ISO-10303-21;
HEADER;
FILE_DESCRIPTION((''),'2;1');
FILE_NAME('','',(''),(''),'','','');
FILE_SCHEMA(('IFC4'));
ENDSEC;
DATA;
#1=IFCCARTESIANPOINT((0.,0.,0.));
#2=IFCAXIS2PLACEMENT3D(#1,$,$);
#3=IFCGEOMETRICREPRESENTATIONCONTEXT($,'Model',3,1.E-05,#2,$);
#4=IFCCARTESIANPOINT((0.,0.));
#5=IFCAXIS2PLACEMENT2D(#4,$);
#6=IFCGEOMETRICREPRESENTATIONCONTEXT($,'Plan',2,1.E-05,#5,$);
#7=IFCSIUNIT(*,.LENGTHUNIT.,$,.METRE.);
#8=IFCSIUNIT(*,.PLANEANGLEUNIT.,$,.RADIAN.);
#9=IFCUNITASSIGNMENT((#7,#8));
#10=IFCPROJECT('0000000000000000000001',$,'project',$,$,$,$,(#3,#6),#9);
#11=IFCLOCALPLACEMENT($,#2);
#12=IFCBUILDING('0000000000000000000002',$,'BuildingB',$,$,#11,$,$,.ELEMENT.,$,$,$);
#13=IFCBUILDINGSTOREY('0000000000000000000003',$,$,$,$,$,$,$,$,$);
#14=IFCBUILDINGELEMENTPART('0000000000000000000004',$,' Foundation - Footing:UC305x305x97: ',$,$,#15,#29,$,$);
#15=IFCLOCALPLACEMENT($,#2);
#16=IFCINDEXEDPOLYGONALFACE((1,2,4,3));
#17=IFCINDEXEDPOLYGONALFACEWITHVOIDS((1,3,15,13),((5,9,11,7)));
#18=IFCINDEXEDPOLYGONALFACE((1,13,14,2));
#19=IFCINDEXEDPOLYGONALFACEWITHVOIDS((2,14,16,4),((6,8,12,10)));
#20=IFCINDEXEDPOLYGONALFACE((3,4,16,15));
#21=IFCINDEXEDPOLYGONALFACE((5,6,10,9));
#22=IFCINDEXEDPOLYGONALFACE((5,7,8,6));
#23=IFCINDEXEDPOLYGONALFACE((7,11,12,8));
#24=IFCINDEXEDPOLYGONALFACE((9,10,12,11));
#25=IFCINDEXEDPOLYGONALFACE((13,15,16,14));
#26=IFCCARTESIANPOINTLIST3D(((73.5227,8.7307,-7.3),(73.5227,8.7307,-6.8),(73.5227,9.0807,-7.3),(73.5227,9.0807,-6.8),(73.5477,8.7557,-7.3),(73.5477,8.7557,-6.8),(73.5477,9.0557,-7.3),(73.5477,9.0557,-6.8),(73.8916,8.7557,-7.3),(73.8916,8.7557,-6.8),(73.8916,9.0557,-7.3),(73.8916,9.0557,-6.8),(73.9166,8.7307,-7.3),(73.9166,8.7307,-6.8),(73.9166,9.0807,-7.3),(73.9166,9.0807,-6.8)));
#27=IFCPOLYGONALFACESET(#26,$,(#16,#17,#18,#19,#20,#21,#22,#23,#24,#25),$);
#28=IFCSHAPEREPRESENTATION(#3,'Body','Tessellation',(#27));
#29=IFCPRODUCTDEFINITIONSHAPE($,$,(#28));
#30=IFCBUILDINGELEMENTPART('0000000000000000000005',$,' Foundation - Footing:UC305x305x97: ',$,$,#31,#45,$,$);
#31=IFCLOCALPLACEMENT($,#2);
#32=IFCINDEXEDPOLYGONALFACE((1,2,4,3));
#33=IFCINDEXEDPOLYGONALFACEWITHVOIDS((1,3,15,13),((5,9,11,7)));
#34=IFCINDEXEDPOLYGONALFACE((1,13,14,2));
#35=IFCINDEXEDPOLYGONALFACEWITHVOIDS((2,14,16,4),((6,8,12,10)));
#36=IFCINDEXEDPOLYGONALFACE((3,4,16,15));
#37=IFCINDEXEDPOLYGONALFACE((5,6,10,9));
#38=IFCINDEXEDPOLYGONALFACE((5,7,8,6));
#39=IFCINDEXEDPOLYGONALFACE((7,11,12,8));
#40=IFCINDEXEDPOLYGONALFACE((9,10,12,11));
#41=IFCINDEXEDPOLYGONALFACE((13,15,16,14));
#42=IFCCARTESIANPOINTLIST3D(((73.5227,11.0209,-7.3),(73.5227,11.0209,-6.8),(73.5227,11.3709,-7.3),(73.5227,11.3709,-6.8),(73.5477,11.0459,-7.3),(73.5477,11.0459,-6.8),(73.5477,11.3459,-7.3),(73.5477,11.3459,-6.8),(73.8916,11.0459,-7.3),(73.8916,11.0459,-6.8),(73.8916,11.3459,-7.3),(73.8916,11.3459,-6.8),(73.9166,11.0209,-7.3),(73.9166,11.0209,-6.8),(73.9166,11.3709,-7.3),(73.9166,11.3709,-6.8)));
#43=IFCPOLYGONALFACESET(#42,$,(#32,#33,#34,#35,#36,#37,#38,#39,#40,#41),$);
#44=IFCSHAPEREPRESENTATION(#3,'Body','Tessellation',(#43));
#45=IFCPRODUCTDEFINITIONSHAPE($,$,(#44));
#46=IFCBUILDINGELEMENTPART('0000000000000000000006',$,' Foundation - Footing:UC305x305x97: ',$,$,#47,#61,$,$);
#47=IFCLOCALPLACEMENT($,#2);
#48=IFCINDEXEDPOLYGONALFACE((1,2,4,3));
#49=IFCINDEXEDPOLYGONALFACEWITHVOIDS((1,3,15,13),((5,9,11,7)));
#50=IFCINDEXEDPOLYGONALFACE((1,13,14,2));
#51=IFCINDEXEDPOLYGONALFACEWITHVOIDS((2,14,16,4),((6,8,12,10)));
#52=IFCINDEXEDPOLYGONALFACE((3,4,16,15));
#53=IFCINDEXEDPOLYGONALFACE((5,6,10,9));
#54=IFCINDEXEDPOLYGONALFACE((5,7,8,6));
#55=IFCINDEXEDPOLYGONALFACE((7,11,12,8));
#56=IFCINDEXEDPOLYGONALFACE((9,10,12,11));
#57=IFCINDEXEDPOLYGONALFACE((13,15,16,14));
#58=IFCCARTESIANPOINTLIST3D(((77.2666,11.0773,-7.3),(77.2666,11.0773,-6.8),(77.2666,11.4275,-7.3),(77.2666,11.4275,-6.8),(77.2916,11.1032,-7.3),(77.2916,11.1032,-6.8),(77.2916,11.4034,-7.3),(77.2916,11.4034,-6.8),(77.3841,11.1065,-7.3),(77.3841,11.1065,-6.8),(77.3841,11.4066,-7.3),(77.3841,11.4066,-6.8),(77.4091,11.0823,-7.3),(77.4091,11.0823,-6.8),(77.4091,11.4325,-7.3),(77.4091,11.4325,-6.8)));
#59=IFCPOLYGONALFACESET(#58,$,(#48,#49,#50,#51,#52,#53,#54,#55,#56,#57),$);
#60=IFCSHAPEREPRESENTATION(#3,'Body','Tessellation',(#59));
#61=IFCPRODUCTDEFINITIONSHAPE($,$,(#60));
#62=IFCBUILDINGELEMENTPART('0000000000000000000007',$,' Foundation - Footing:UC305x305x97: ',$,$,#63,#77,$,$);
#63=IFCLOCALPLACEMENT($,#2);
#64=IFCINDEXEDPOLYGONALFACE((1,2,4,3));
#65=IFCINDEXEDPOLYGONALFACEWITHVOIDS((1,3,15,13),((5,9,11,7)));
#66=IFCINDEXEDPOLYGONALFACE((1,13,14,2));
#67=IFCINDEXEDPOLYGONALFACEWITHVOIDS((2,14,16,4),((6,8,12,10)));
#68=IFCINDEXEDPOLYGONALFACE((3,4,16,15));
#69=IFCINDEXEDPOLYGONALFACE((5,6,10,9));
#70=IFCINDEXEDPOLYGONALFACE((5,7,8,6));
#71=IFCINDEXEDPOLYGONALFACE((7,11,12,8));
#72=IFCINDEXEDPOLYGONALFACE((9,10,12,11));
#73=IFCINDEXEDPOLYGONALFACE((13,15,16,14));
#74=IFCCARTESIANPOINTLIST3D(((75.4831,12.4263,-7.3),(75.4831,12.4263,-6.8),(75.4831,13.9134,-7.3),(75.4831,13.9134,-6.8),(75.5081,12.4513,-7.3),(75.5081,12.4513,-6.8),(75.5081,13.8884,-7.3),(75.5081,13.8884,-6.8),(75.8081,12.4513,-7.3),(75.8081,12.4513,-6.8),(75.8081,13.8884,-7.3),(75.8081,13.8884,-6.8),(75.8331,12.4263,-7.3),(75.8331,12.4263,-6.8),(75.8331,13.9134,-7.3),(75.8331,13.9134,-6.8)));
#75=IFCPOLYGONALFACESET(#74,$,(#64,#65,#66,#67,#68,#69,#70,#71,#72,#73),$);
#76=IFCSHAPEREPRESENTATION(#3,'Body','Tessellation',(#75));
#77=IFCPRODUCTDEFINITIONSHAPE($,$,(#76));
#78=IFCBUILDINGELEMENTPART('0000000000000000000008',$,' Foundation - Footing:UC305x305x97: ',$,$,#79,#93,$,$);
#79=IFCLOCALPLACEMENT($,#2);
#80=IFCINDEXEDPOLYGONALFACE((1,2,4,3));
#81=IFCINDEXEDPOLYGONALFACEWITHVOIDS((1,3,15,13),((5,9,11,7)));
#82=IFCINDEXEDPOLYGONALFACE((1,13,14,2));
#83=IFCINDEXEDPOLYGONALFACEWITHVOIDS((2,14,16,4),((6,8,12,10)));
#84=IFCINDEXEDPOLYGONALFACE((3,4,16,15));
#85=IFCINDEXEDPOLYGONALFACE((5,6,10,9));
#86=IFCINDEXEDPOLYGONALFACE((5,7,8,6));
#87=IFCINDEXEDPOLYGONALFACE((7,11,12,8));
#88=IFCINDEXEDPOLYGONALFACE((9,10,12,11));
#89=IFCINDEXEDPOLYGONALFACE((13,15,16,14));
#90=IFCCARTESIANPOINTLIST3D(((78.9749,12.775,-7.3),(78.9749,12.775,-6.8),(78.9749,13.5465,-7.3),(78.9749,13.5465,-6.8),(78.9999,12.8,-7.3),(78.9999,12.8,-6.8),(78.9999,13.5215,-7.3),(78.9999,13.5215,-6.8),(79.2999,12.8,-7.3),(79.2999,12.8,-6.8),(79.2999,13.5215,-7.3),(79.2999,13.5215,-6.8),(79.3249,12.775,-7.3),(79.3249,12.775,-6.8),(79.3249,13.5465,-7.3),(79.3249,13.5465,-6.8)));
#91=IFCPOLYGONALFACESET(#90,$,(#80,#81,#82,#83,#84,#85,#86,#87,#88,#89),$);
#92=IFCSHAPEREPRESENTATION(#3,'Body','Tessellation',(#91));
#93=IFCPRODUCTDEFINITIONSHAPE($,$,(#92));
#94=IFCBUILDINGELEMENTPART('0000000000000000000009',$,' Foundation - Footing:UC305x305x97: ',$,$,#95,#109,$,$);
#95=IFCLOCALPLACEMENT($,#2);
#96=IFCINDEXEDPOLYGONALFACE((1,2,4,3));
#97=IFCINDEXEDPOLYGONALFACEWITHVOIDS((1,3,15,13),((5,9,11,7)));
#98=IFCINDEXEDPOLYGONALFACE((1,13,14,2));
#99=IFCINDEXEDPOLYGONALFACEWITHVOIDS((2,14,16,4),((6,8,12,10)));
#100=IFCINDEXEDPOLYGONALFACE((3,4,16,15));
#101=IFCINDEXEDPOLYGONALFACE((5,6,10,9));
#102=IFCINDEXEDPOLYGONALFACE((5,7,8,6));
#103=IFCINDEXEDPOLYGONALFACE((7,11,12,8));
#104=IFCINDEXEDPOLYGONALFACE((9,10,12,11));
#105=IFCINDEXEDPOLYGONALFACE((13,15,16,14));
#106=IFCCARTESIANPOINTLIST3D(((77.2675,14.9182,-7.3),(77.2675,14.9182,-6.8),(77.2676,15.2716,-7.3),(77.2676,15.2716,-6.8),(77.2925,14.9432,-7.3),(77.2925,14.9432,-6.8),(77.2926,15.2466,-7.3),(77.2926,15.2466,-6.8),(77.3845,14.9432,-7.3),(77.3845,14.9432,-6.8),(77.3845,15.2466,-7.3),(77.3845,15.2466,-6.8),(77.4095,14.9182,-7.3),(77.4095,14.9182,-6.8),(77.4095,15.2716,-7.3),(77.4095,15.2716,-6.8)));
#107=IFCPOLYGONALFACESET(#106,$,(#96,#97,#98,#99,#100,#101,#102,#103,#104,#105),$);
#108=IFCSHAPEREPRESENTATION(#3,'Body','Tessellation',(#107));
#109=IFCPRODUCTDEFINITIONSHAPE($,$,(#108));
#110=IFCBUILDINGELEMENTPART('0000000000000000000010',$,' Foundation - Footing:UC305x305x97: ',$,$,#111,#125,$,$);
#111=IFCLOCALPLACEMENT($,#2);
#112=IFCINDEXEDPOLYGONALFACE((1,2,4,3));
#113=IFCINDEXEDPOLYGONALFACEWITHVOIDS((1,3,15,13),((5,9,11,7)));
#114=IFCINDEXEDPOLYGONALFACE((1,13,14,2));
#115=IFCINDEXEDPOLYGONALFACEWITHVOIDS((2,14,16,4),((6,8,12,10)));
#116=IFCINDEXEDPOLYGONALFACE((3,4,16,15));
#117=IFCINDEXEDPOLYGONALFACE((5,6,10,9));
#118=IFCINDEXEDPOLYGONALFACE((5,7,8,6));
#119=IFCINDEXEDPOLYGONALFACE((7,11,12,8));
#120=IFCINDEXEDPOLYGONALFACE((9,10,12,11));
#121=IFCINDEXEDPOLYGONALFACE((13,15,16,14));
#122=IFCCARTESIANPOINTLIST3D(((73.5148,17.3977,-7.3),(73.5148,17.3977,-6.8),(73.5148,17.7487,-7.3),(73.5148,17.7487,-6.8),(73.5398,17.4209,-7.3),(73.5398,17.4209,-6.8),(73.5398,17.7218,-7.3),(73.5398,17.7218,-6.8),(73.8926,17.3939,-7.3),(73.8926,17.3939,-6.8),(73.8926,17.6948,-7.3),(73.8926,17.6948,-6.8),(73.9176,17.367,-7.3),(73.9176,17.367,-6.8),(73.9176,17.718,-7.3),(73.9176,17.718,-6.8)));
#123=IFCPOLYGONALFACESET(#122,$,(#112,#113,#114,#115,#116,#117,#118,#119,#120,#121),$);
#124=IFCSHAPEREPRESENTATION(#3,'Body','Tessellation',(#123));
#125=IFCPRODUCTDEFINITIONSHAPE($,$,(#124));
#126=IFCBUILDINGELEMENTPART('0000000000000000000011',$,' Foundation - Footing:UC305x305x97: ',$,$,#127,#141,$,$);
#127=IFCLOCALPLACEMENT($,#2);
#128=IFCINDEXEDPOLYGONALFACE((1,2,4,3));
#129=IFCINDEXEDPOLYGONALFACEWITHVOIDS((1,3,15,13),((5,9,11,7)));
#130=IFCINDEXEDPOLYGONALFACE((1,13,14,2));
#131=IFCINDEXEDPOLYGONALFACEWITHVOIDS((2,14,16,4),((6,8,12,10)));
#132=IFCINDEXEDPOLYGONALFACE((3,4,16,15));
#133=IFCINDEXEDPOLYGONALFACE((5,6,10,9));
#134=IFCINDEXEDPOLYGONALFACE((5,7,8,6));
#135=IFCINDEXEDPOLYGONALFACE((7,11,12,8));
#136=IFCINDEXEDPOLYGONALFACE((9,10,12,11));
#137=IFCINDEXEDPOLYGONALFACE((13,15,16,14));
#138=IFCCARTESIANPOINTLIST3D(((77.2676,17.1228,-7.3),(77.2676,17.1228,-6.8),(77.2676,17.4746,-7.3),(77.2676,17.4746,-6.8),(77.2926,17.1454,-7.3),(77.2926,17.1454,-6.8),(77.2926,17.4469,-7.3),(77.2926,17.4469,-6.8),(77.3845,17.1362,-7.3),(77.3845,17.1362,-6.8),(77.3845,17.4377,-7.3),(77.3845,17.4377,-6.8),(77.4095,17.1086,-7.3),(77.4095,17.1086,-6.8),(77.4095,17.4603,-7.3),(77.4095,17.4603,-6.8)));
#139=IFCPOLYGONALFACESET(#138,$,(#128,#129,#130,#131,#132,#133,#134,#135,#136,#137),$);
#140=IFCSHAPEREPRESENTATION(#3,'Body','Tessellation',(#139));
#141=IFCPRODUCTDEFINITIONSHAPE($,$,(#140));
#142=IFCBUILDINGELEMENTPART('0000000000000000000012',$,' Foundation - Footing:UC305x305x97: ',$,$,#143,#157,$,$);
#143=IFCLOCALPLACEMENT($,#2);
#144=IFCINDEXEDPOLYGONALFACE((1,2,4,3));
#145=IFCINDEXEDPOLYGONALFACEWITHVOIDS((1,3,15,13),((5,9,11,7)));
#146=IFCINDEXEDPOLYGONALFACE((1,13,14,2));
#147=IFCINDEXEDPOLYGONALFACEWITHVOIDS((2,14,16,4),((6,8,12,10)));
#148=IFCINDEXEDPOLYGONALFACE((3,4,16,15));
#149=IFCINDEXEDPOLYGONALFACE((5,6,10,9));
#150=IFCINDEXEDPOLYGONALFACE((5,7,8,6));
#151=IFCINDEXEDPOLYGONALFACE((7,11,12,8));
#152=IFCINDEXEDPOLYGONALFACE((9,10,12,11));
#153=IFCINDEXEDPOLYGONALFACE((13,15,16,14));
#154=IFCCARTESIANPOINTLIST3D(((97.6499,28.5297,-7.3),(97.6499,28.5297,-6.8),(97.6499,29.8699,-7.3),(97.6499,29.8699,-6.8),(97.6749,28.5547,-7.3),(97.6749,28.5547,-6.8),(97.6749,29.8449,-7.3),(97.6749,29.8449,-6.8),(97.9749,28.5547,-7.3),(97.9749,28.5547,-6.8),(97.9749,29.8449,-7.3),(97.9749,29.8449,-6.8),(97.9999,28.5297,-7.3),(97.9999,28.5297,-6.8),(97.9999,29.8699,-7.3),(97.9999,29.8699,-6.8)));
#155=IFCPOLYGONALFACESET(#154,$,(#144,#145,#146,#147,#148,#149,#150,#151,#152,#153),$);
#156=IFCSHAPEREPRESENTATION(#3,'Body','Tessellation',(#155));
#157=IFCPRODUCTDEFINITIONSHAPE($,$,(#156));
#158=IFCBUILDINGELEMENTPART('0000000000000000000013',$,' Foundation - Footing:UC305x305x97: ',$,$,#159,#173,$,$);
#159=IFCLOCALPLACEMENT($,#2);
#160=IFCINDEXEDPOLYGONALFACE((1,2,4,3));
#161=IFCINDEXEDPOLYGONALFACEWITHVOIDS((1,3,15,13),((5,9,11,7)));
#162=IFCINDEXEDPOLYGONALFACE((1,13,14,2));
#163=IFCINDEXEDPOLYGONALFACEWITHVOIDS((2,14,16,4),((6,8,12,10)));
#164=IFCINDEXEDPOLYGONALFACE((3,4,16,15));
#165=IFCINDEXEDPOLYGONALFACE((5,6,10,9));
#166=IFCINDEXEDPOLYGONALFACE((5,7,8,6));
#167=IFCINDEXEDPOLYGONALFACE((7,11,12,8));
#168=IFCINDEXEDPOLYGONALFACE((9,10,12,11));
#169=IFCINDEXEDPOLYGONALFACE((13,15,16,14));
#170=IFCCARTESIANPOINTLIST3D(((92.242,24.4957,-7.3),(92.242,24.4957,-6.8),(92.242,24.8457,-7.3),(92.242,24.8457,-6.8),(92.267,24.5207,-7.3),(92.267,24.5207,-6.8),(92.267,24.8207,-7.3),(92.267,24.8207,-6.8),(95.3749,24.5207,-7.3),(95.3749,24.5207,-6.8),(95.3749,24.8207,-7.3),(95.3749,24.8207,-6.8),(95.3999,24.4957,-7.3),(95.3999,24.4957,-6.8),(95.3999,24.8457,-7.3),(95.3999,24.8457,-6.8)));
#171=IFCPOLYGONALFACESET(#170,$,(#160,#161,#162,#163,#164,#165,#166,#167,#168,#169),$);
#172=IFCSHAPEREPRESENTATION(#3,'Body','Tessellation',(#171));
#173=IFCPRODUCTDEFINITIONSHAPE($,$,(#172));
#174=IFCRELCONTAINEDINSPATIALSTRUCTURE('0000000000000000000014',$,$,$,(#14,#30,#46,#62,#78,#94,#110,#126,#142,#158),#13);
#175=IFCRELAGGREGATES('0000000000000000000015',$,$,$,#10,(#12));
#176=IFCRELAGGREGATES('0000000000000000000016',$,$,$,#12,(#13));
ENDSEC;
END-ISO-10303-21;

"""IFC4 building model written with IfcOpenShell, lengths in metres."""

from ifc_helpers import new_model, si_unit, origin, origin_2d, place, context, project, spatial, polyline, outline, extrude, element, save


model = new_model("IFC4")

# Units and contexts
model_context = context("Model", 3, precision=1e-05, world=origin())
plan_context = context("Plan", 2, precision=1e-05, world=origin_2d())
ifc_project = project(units=[si_unit("LENGTHUNIT", "METRE"), si_unit("PLANEANGLEUNIT", "RADIAN")], contexts=[model_context, plan_context])

# Building, storey
building_placement = place(None, origin())
building = spatial("IfcBuilding", under=ifc_project, at=building_placement, Name="BuildingB", CompositionType="ELEMENT")
storey = spatial("IfcBuildingStorey", under=building)

# Building element parts, openings
building_element_part_1 = element("IfcBuildingElementPart", 1, inside=storey, Name=" Foundation - Footing:UC305x305x97: ", context=model_context, shape_type="SweptSolid", body=[
    extrude(outline(polyline([(73.9166, 8.7307, -7.3), (73.5227, 8.7307, -7.3), (73.5227, 9.0807, -7.3), (73.9166, 9.0807, -7.3), (73.9166, 8.7307, -7.3)])), None, (0.0, 0.0, 1.0), 0.5),
])
element("IfcOpeningElement", 2, inside=storey, cuts=building_element_part_1, context=model_context, shape_type="SweptSolid", body=[
    extrude(outline(polyline([(73.8916, 8.7557, -7.3), (73.5477, 8.7557, -7.3), (73.5477, 9.0557, -7.3), (73.8916, 9.0557, -7.3), (73.8916, 8.7557, -7.3)])), None, (0.0, 0.0, 1.0), 0.5),
])
building_element_part_2 = element("IfcBuildingElementPart", 3, inside=storey, Name=" Foundation - Footing:UC305x305x97: ", context=model_context, shape_type="SweptSolid", body=[
    extrude(outline(polyline([(73.9166, 11.0209, -7.3), (73.5227, 11.0209, -7.3), (73.5227, 11.3709, -7.3), (73.9166, 11.3709, -7.3), (73.9166, 11.0209, -7.3)])), None, (0.0, 0.0, 1.0), 0.5),
])
element("IfcOpeningElement", 4, inside=storey, cuts=building_element_part_2, context=model_context, shape_type="SweptSolid", body=[
    extrude(outline(polyline([(73.8916, 11.0459, -7.3), (73.5477, 11.0459, -7.3), (73.5477, 11.3459, -7.3), (73.8916, 11.3459, -7.3), (73.8916, 11.0459, -7.3)])), None, (0.0, 0.0, 1.0), 0.5),
])
building_element_part_3 = element("IfcBuildingElementPart", 5, inside=storey, Name=" Foundation - Footing:UC305x305x97: ", context=model_context, shape_type="SweptSolid", body=[
    extrude(outline(polyline([(77.4091, 11.0823, -7.3), (77.2666, 11.0773, -7.3), (77.2666, 11.4275, -7.3), (77.4091, 11.4325, -7.3), (77.4091, 11.0823, -7.3)])), None, (0.0, 0.0, 1.0), 0.5),
])
element("IfcOpeningElement", 6, inside=storey, cuts=building_element_part_3, context=model_context, shape_type="SweptSolid", body=[
    extrude(outline(polyline([(77.3841, 11.1065, -7.3), (77.2916, 11.1032, -7.3), (77.2916, 11.4034, -7.3), (77.3841, 11.4066, -7.3), (77.3841, 11.1065, -7.3)])), None, (0.0, 0.0, 1.0), 0.5),
])
building_element_part_4 = element("IfcBuildingElementPart", 7, inside=storey, Name=" Foundation - Footing:UC305x305x97: ", context=model_context, shape_type="SweptSolid", body=[
    extrude(outline(polyline([(75.8331, 12.4263, -7.3), (75.4831, 12.4263, -7.3), (75.4831, 13.9134, -7.3), (75.8331, 13.9134, -7.3), (75.8331, 12.4263, -7.3)])), None, (0.0, 0.0, 1.0), 0.5),
])
element("IfcOpeningElement", 8, inside=storey, cuts=building_element_part_4, context=model_context, shape_type="SweptSolid", body=[
    extrude(outline(polyline([(75.8081, 12.4513, -7.3), (75.5081, 12.4513, -7.3), (75.5081, 13.8884, -7.3), (75.8081, 13.8884, -7.3), (75.8081, 12.4513, -7.3)])), None, (0.0, 0.0, 1.0), 0.5),
])
building_element_part_5 = element("IfcBuildingElementPart", 9, inside=storey, Name=" Foundation - Footing:UC305x305x97: ", context=model_context, shape_type="SweptSolid", body=[
    extrude(outline(polyline([(79.3249, 12.775, -7.3), (78.9749, 12.775, -7.3), (78.9749, 13.5465, -7.3), (79.3249, 13.5465, -7.3), (79.3249, 12.775, -7.3)])), None, (0.0, 0.0, 1.0), 0.5),
])
element("IfcOpeningElement", 10, inside=storey, cuts=building_element_part_5, context=model_context, shape_type="SweptSolid", body=[
    extrude(outline(polyline([(79.2999, 12.8, -7.3), (78.9999, 12.8, -7.3), (78.9999, 13.5215, -7.3), (79.2999, 13.5215, -7.3), (79.2999, 12.8, -7.3)])), None, (0.0, 0.0, 1.0), 0.5),
])
building_element_part_6 = element("IfcBuildingElementPart", 11, inside=storey, Name=" Foundation - Footing:UC305x305x97: ", context=model_context, shape_type="SweptSolid", body=[
    extrude(outline(polyline([(77.4095, 14.9182, -7.3), (77.2675, 14.9182, -7.3), (77.2676, 15.2716, -7.3), (77.4095, 15.2716, -7.3), (77.4095, 14.9182, -7.3)])), None, (0.0, 0.0, 1.0), 0.5),
])
element("IfcOpeningElement", 12, inside=storey, cuts=building_element_part_6, context=model_context, shape_type="SweptSolid", body=[
    extrude(outline(polyline([(77.3845, 14.9432, -7.3), (77.2925, 14.9432, -7.3), (77.2926, 15.2466, -7.3), (77.3845, 15.2466, -7.3), (77.3845, 14.9432, -7.3)])), None, (0.0, 0.0, 1.0), 0.5),
])
building_element_part_7 = element("IfcBuildingElementPart", 13, inside=storey, Name=" Foundation - Footing:UC305x305x97: ", context=model_context, shape_type="SweptSolid", body=[
    extrude(outline(polyline([(73.9176, 17.367, -7.3), (73.5148, 17.3977, -7.3), (73.5148, 17.7487, -7.3), (73.9176, 17.718, -7.3), (73.9176, 17.367, -7.3)])), None, (0.0, 0.0, 1.0), 0.5),
])
element("IfcOpeningElement", 14, inside=storey, cuts=building_element_part_7, context=model_context, shape_type="SweptSolid", body=[
    extrude(outline(polyline([(73.8926, 17.3939, -7.3), (73.5398, 17.4209, -7.3), (73.5398, 17.7218, -7.3), (73.8926, 17.6948, -7.3), (73.8926, 17.3939, -7.3)])), None, (0.0, 0.0, 1.0), 0.5),
])
building_element_part_8 = element("IfcBuildingElementPart", 15, inside=storey, Name=" Foundation - Footing:UC305x305x97: ", context=model_context, shape_type="SweptSolid", body=[
    extrude(outline(polyline([(77.4095, 17.1086, -7.3), (77.2676, 17.1228, -7.3), (77.2676, 17.4746, -7.3), (77.4095, 17.4603, -7.3), (77.4095, 17.1086, -7.3)])), None, (0.0, 0.0, 1.0), 0.5),
])
element("IfcOpeningElement", 16, inside=storey, cuts=building_element_part_8, context=model_context, shape_type="SweptSolid", body=[
    extrude(outline(polyline([(77.3845, 17.1362, -7.3), (77.2926, 17.1454, -7.3), (77.2926, 17.4469, -7.3), (77.3845, 17.4377, -7.3), (77.3845, 17.1362, -7.3)])), None, (0.0, 0.0, 1.0), 0.5),
])
building_element_part_9 = element("IfcBuildingElementPart", 17, inside=storey, Name=" Foundation - Footing:UC305x305x97: ", context=model_context, shape_type="SweptSolid", body=[
    extrude(outline(polyline([(97.9999, 28.5297, -7.3), (97.6499, 28.5297, -7.3), (97.6499, 29.8699, -7.3), (97.9999, 29.8699, -7.3), (97.9999, 28.5297, -7.3)])), None, (0.0, 0.0, 1.0), 0.5),
])
element("IfcOpeningElement", 18, inside=storey, cuts=building_element_part_9, context=model_context, shape_type="SweptSolid", body=[
    extrude(outline(polyline([(97.9749, 28.5547, -7.3), (97.6749, 28.5547, -7.3), (97.6749, 29.8449, -7.3), (97.9749, 29.8449, -7.3), (97.9749, 28.5547, -7.3)])), None, (0.0, 0.0, 1.0), 0.5),
])
building_element_part_10 = element("IfcBuildingElementPart", 19, inside=storey, Name=" Foundation - Footing:UC305x305x97: ", context=model_context, shape_type="SweptSolid", body=[
    extrude(outline(polyline([(95.3999, 24.4957, -7.3), (95.3999, 24.8457, -7.3), (92.242, 24.8457, -7.3), (92.242, 24.4957, -7.3), (95.3999, 24.4957, -7.3)])), None, (0.0, 0.0, 1.0), 0.5),
])
element("IfcOpeningElement", 20, inside=storey, cuts=building_element_part_10, context=model_context, shape_type="SweptSolid", body=[
    extrude(outline(polyline([(95.3749, 24.5207, -7.3), (95.3749, 24.8207, -7.3), (92.267, 24.8207, -7.3), (92.267, 24.5207, -7.3), (95.3749, 24.5207, -7.3)])), None, (0.0, 0.0, 1.0), 0.5),
])

save(model, "model.ifc")
